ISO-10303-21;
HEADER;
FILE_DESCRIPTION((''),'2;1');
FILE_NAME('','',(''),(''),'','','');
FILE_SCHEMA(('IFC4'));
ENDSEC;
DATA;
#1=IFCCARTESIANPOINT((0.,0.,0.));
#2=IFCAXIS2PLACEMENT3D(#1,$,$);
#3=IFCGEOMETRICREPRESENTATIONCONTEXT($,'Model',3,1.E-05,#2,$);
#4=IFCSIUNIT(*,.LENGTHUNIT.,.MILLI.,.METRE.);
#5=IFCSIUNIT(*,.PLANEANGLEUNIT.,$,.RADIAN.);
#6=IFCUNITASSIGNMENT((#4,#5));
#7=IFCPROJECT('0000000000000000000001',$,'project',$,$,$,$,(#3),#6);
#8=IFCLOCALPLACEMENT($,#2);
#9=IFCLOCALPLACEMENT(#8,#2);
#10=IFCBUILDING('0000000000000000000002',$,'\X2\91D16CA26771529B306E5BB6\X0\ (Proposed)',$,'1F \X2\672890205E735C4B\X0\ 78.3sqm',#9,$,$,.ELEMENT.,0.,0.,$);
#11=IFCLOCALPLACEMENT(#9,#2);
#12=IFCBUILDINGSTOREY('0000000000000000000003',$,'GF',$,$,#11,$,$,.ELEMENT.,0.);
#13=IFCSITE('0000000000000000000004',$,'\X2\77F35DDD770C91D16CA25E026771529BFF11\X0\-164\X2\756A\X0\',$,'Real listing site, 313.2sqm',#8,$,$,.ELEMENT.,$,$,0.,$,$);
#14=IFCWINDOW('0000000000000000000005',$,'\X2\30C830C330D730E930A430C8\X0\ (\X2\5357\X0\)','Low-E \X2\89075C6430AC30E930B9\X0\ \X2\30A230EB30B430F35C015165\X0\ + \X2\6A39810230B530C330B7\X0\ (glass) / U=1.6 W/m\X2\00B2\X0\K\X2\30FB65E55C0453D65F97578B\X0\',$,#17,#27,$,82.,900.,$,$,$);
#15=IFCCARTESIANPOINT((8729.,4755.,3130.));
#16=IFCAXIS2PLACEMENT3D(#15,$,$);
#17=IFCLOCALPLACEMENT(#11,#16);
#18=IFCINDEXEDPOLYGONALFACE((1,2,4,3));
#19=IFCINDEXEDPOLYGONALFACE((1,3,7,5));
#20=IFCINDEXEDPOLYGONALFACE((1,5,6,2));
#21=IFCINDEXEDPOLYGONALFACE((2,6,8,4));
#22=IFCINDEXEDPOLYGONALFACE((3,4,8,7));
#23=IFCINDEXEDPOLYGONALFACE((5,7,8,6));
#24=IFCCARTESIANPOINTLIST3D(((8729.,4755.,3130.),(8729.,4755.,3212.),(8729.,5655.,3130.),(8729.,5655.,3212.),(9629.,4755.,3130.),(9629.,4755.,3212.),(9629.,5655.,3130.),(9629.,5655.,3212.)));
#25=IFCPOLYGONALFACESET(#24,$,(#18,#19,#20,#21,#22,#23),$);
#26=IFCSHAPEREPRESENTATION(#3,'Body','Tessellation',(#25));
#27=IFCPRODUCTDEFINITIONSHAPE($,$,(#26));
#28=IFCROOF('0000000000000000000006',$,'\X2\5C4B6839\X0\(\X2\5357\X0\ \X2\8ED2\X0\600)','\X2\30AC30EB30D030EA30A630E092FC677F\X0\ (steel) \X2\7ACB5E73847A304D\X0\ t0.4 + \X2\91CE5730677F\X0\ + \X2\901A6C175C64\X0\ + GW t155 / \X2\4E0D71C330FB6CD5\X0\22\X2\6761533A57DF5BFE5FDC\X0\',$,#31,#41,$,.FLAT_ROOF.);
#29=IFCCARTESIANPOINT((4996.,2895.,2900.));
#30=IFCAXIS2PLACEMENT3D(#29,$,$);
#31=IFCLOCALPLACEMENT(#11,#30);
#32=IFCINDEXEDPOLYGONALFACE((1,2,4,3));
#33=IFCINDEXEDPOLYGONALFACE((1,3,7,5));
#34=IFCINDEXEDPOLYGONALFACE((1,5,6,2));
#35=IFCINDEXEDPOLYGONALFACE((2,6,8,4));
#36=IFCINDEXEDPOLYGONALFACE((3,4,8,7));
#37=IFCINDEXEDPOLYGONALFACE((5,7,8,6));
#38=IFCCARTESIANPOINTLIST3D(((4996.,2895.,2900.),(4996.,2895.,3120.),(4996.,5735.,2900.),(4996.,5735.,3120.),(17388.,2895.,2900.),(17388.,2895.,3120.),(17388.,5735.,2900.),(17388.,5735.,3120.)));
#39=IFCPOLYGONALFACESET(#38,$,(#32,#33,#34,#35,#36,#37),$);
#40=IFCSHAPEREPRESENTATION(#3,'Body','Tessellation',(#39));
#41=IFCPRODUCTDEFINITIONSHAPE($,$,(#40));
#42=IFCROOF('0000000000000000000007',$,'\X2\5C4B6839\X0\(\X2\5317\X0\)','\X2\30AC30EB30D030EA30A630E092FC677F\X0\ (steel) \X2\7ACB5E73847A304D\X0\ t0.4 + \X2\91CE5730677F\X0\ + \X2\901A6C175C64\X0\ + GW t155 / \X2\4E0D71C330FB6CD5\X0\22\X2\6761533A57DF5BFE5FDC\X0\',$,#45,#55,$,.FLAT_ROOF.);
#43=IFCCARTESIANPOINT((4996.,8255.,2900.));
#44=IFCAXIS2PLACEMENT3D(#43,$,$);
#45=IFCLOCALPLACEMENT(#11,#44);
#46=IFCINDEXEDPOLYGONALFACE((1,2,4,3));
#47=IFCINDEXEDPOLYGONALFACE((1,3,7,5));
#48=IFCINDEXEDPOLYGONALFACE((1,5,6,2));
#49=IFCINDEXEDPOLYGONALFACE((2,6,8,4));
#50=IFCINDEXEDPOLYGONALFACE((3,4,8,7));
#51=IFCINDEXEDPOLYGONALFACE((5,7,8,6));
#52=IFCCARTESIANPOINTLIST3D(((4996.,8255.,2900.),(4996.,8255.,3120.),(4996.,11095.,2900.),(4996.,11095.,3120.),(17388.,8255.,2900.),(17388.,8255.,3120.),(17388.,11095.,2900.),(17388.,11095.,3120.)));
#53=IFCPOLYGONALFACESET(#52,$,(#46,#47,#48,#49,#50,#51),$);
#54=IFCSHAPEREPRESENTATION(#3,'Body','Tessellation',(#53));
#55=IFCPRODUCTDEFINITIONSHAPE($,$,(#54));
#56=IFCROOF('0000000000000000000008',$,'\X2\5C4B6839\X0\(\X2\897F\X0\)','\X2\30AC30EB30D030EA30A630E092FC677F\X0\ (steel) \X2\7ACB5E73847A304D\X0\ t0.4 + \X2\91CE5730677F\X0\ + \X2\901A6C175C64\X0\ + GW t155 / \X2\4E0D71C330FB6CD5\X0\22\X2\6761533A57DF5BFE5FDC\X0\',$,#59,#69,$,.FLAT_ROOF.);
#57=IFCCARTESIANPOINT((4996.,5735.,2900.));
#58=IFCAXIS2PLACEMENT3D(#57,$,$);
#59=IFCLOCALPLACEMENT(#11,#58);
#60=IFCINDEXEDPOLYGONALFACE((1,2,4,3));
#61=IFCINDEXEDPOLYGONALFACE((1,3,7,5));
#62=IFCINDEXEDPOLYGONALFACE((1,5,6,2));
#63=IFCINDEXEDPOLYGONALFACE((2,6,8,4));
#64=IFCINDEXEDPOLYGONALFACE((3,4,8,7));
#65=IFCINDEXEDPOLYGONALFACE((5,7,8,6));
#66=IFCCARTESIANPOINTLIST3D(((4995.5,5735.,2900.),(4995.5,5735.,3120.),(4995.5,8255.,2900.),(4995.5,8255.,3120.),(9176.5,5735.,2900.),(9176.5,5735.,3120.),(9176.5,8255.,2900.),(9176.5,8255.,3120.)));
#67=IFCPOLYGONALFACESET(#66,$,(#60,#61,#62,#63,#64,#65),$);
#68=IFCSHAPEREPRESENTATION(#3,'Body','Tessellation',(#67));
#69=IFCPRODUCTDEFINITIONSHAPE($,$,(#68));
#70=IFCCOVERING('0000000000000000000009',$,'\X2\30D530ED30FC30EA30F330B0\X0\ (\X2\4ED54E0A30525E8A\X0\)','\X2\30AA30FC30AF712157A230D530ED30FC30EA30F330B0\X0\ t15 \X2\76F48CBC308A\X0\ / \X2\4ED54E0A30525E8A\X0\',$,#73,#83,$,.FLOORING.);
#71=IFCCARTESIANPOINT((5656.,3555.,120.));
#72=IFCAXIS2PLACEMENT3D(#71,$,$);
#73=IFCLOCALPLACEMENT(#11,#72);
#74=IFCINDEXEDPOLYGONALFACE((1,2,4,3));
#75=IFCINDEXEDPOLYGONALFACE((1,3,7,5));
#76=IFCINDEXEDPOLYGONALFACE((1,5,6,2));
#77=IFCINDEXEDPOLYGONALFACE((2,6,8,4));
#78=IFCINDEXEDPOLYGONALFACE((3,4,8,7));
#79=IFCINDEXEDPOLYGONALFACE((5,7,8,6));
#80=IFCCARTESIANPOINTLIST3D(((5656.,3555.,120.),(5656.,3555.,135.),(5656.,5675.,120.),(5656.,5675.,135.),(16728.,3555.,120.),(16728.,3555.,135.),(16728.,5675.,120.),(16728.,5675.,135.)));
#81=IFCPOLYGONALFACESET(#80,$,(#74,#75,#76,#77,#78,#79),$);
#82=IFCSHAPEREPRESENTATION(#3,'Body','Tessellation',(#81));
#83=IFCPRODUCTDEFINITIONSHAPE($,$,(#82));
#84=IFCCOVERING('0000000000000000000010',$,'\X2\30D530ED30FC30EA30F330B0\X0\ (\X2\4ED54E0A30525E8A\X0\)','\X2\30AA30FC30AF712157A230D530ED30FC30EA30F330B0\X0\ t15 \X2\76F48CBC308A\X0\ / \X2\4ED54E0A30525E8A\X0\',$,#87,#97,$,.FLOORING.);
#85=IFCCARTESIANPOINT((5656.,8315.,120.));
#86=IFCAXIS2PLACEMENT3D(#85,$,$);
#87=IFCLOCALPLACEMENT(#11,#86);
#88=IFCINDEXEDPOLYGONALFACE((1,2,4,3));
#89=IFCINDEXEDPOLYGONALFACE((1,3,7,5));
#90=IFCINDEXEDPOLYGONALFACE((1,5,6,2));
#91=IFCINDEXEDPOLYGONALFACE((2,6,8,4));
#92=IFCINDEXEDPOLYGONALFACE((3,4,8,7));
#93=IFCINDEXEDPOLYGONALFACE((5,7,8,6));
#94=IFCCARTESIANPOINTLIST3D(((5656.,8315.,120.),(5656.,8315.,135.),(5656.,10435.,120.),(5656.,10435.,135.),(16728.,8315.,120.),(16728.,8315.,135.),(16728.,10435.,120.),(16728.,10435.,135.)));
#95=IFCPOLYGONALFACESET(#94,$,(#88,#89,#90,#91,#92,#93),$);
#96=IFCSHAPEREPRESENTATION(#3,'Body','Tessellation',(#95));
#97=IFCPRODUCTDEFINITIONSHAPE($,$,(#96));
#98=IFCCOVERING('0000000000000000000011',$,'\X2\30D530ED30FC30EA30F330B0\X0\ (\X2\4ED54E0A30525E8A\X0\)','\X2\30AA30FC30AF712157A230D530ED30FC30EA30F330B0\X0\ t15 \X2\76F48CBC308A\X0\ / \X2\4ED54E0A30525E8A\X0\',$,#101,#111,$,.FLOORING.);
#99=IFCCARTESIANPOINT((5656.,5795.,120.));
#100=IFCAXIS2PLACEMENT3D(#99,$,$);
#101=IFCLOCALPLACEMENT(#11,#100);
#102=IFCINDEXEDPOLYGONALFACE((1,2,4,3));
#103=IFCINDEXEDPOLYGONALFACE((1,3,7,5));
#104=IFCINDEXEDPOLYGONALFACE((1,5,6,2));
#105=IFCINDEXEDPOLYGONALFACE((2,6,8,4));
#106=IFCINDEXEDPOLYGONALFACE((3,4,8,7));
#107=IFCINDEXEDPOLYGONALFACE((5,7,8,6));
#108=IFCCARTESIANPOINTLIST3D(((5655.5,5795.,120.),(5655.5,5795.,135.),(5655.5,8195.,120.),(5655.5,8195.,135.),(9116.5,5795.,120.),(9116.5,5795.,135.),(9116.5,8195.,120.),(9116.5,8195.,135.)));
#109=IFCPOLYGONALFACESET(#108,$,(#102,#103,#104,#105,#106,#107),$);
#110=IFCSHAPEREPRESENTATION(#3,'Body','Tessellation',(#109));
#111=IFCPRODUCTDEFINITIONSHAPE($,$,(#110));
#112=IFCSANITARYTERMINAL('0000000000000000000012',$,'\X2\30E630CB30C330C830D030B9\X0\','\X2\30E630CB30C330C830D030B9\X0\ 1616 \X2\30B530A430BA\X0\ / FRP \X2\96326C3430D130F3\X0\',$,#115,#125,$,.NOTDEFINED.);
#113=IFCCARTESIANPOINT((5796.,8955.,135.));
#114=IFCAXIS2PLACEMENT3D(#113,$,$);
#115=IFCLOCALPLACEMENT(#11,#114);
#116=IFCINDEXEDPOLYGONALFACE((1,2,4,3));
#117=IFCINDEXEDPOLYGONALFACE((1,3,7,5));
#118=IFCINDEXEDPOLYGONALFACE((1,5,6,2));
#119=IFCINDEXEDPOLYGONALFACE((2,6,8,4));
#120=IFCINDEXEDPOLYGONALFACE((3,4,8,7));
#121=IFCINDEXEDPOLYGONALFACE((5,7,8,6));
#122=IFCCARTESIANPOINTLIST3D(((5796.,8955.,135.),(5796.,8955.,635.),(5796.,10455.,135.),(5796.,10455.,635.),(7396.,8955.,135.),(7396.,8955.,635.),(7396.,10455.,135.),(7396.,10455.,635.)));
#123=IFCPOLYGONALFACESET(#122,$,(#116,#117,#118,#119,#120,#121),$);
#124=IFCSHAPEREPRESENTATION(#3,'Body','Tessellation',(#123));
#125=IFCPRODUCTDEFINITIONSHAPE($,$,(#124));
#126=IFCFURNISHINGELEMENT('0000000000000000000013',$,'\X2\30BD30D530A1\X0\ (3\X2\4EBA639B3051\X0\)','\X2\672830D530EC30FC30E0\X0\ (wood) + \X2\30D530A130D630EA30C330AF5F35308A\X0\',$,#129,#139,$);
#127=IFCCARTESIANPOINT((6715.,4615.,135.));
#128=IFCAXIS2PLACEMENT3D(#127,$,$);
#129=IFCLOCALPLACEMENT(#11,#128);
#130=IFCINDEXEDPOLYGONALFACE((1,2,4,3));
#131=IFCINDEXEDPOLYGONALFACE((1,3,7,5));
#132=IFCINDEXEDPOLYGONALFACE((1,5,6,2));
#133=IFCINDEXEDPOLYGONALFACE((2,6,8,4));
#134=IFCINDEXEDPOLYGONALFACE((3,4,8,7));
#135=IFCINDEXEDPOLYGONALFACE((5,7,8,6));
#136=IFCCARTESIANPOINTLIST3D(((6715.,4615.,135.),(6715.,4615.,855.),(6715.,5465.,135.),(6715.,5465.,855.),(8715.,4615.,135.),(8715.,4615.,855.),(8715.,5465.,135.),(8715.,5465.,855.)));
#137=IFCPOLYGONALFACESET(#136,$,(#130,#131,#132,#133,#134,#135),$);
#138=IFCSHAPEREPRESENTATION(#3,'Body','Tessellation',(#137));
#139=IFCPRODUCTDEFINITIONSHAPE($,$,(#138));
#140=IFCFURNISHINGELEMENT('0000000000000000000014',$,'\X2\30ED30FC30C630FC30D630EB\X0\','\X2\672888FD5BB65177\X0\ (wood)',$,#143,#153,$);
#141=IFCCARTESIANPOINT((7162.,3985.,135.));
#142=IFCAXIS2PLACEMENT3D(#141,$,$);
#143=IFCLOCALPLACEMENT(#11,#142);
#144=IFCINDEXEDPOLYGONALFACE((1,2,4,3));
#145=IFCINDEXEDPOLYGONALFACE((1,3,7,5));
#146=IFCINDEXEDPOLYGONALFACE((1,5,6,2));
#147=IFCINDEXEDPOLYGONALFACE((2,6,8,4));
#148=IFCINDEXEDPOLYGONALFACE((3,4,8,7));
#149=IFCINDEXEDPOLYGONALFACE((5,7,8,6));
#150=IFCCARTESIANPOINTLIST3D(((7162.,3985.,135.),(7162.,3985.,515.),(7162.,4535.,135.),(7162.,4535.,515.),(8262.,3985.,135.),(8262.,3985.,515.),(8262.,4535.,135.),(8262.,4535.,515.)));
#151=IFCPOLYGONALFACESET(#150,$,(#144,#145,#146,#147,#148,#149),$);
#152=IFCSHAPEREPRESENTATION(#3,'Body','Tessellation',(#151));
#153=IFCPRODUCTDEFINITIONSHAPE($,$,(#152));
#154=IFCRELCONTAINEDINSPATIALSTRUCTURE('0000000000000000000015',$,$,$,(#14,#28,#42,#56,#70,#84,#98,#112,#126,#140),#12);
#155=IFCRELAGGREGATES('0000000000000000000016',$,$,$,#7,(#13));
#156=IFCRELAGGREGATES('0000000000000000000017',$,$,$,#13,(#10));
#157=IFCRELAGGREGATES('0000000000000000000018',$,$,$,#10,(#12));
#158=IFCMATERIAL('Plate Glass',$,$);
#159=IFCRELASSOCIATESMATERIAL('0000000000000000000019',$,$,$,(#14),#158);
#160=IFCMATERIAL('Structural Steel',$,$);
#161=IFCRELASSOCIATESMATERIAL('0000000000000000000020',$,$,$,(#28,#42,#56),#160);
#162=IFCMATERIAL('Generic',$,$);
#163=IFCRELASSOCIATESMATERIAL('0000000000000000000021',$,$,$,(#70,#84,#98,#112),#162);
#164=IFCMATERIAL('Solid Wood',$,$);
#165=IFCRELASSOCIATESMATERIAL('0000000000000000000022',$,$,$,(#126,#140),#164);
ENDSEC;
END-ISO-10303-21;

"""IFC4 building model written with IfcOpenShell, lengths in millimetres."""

from ifc_helpers import new_model, si_unit, frame, frame_2d, origin, place, context, project, spatial, rectangle, extrude, material, element, save


model = new_model("IFC4")

# Units and contexts
model_context = context("Model", 3, precision=1e-05, world=origin())
ifc_project = project(units=[si_unit("LENGTHUNIT", "METRE", prefix="MILLI"), si_unit("PLANEANGLEUNIT", "RADIAN")], contexts=[model_context])

# Site, building, storey
site_placement = place(None, origin())
site = spatial("IfcSite", under=ifc_project, at=site_placement, Name="石川県金沢市東力１-164番", ObjectType="Real listing site, 313.2sqm", CompositionType="ELEMENT", RefElevation=0.0)
building_placement = place(site_placement, origin())
building = spatial("IfcBuilding", under=site, at=building_placement, Name="金沢東力の家 (Proposed)", ObjectType="1F 木造平屋 78.3sqm", CompositionType="ELEMENT", ElevationOfRefHeight=0.0, ElevationOfTerrain=0.0)
storey_placement = place(building_placement, origin())
storey = spatial("IfcBuildingStorey", under=building, at=storey_placement, Name="GF", CompositionType="ELEMENT", Elevation=0.0)

# Shared definitions
ifc_material_1 = material(Name="Solid Wood")

# Shared definitions
ifc_material_2 = material(Name="Plate Glass")

# Window
window_1_placement = place(storey_placement, frame((8729.0, 4755.0, 3130.0)))
element("IfcWindow", 1, at=window_1_placement, inside=storey, material=ifc_material_2, Name="トップライト (南)", Description="Low-E 複層ガラス アルゴン封入 + 樹脂サッシ (glass) / U=1.6 W/m²K・日射取得型", OverallHeight=82.0, OverallWidth=900.0, context=model_context, shape_type="SweptSolid", body=[
    extrude(rectangle(XDim=900.0, YDim=900.0, at=frame_2d((450.0, 450.0))), frame((8729.0, 4755.0, 3130.0)), (0.0, 0.0, 1.0), 82.0),
])

# Roofs
ifc_material_3 = material(Name="Structural Steel")
roof_1_placement = place(storey_placement, frame((4996.0, 2895.0, 2900.0)))
element("IfcRoof", 2, at=roof_1_placement, inside=storey, material=ifc_material_3, Name="屋根(南 軒600)", Description="ガルバリウム鋼板 (steel) 立平葺き t0.4 + 野地板 + 通気層 + GW t155 / 不燃・法22条区域対応", PredefinedType="FLAT_ROOF", context=model_context, shape_type="SweptSolid", body=[
    extrude(rectangle(XDim=12392.0, YDim=2840.0, at=frame_2d((6196.0, 1420.0))), frame((4996.0, 2895.0, 2900.0)), (0.0, 0.0, 1.0), 220.0),
])
roof_2_placement = place(storey_placement, frame((4996.0, 8255.0, 2900.0)))
element("IfcRoof", 3, at=roof_2_placement, inside=storey, material=ifc_material_3, Name="屋根(北)", Description="ガルバリウム鋼板 (steel) 立平葺き t0.4 + 野地板 + 通気層 + GW t155 / 不燃・法22条区域対応", PredefinedType="FLAT_ROOF", context=model_context, shape_type="SweptSolid", body=[
    extrude(rectangle(XDim=12392.0, YDim=2840.0, at=frame_2d((6196.0, 1420.0))), frame((4996.0, 8255.0, 2900.0)), (0.0, 0.0, 1.0), 220.0),
])
roof_3_placement = place(storey_placement, frame((4996.0, 5735.0, 2900.0)))
element("IfcRoof", 4, at=roof_3_placement, inside=storey, material=ifc_material_3, Name="屋根(西)", Description="ガルバリウム鋼板 (steel) 立平葺き t0.4 + 野地板 + 通気層 + GW t155 / 不燃・法22条区域対応", PredefinedType="FLAT_ROOF", context=model_context, shape_type="SweptSolid", body=[
    extrude(rectangle(XDim=4181.0, YDim=2520.0, at=frame_2d((2090.0, 1260.0))), frame((4996.0, 5735.0, 2900.0)), (0.0, 0.0, 1.0), 220.0),
])

# Coverings
ifc_material_4 = material(Name="Generic")
covering_1_placement = place(storey_placement, frame((5656.0, 3555.0, 120.0)))
element("IfcCovering", 5, at=covering_1_placement, inside=storey, material=ifc_material_4, Name="フローリング (仕上げ床)", Description="オーク無垢フローリング t15 直貼り / 仕上げ床", PredefinedType="FLOORING", context=model_context, shape_type="SweptSolid", body=[
    extrude(rectangle(XDim=11072.0, YDim=2120.0, at=frame_2d((5536.0, 1060.0))), frame((5656.0, 3555.0, 120.0)), (0.0, 0.0, 1.0), 15.0),
])
covering_2_placement = place(storey_placement, frame((5656.0, 8315.0, 120.0)))
element("IfcCovering", 6, at=covering_2_placement, inside=storey, material=ifc_material_4, Name="フローリング (仕上げ床)", Description="オーク無垢フローリング t15 直貼り / 仕上げ床", PredefinedType="FLOORING", context=model_context, shape_type="SweptSolid", body=[
    extrude(rectangle(XDim=11072.0, YDim=2120.0, at=frame_2d((5536.0, 1060.0))), frame((5656.0, 8315.0, 120.0)), (0.0, 0.0, 1.0), 15.0),
])
covering_3_placement = place(storey_placement, frame((5656.0, 5795.0, 120.0)))
element("IfcCovering", 7, at=covering_3_placement, inside=storey, material=ifc_material_4, Name="フローリング (仕上げ床)", Description="オーク無垢フローリング t15 直貼り / 仕上げ床", PredefinedType="FLOORING", context=model_context, shape_type="SweptSolid", body=[
    extrude(rectangle(XDim=3461.0, YDim=2400.0, at=frame_2d((1730.0, 1200.0))), frame((5656.0, 5795.0, 120.0)), (0.0, 0.0, 1.0), 15.0),
])

# Sanitary terminal
sanitary_terminal_placement = place(storey_placement, frame((5796.0, 8955.0, 135.0)))
element("IfcSanitaryTerminal", 8, at=sanitary_terminal_placement, inside=storey, material=ifc_material_4, Name="ユニットバス", Description="ユニットバス 1616 サイズ / FRP 防水パン", PredefinedType="NOTDEFINED", context=model_context, shape_type="SweptSolid", body=[
    extrude(rectangle(XDim=1600.0, YDim=1500.0, at=frame_2d((800.0, 750.0))), frame((5796.0, 8955.0, 135.0)), (0.0, 0.0, 1.0), 500.0),
])

# Furnishing elements
furnishing_1_placement = place(storey_placement, frame((6715.0, 4615.0, 135.0)))
element("IfcFurnishingElement", 9, at=furnishing_1_placement, inside=storey, material=ifc_material_1, Name="ソファ (3人掛け)", Description="木フレーム (wood) + ファブリック張り", context=model_context, shape_type="SweptSolid", body=[
    extrude(rectangle(XDim=2000.0, YDim=850.0, at=frame_2d((1000.0, 425.0))), frame((6715.0, 4615.0, 135.0)), (0.0, 0.0, 1.0), 720.0),
])
furnishing_2_placement = place(storey_placement, frame((7162.0, 3985.0, 135.0)))
element("IfcFurnishingElement", 10, at=furnishing_2_placement, inside=storey, material=ifc_material_1, Name="ローテーブル", Description="木製家具 (wood)", context=model_context, shape_type="SweptSolid", body=[
    extrude(rectangle(XDim=1100.0, YDim=550.0, at=frame_2d((550.0, 275.0))), frame((7162.0, 3985.0, 135.0)), (0.0, 0.0, 1.0), 380.0),
])

save(model, "model.ifc")
